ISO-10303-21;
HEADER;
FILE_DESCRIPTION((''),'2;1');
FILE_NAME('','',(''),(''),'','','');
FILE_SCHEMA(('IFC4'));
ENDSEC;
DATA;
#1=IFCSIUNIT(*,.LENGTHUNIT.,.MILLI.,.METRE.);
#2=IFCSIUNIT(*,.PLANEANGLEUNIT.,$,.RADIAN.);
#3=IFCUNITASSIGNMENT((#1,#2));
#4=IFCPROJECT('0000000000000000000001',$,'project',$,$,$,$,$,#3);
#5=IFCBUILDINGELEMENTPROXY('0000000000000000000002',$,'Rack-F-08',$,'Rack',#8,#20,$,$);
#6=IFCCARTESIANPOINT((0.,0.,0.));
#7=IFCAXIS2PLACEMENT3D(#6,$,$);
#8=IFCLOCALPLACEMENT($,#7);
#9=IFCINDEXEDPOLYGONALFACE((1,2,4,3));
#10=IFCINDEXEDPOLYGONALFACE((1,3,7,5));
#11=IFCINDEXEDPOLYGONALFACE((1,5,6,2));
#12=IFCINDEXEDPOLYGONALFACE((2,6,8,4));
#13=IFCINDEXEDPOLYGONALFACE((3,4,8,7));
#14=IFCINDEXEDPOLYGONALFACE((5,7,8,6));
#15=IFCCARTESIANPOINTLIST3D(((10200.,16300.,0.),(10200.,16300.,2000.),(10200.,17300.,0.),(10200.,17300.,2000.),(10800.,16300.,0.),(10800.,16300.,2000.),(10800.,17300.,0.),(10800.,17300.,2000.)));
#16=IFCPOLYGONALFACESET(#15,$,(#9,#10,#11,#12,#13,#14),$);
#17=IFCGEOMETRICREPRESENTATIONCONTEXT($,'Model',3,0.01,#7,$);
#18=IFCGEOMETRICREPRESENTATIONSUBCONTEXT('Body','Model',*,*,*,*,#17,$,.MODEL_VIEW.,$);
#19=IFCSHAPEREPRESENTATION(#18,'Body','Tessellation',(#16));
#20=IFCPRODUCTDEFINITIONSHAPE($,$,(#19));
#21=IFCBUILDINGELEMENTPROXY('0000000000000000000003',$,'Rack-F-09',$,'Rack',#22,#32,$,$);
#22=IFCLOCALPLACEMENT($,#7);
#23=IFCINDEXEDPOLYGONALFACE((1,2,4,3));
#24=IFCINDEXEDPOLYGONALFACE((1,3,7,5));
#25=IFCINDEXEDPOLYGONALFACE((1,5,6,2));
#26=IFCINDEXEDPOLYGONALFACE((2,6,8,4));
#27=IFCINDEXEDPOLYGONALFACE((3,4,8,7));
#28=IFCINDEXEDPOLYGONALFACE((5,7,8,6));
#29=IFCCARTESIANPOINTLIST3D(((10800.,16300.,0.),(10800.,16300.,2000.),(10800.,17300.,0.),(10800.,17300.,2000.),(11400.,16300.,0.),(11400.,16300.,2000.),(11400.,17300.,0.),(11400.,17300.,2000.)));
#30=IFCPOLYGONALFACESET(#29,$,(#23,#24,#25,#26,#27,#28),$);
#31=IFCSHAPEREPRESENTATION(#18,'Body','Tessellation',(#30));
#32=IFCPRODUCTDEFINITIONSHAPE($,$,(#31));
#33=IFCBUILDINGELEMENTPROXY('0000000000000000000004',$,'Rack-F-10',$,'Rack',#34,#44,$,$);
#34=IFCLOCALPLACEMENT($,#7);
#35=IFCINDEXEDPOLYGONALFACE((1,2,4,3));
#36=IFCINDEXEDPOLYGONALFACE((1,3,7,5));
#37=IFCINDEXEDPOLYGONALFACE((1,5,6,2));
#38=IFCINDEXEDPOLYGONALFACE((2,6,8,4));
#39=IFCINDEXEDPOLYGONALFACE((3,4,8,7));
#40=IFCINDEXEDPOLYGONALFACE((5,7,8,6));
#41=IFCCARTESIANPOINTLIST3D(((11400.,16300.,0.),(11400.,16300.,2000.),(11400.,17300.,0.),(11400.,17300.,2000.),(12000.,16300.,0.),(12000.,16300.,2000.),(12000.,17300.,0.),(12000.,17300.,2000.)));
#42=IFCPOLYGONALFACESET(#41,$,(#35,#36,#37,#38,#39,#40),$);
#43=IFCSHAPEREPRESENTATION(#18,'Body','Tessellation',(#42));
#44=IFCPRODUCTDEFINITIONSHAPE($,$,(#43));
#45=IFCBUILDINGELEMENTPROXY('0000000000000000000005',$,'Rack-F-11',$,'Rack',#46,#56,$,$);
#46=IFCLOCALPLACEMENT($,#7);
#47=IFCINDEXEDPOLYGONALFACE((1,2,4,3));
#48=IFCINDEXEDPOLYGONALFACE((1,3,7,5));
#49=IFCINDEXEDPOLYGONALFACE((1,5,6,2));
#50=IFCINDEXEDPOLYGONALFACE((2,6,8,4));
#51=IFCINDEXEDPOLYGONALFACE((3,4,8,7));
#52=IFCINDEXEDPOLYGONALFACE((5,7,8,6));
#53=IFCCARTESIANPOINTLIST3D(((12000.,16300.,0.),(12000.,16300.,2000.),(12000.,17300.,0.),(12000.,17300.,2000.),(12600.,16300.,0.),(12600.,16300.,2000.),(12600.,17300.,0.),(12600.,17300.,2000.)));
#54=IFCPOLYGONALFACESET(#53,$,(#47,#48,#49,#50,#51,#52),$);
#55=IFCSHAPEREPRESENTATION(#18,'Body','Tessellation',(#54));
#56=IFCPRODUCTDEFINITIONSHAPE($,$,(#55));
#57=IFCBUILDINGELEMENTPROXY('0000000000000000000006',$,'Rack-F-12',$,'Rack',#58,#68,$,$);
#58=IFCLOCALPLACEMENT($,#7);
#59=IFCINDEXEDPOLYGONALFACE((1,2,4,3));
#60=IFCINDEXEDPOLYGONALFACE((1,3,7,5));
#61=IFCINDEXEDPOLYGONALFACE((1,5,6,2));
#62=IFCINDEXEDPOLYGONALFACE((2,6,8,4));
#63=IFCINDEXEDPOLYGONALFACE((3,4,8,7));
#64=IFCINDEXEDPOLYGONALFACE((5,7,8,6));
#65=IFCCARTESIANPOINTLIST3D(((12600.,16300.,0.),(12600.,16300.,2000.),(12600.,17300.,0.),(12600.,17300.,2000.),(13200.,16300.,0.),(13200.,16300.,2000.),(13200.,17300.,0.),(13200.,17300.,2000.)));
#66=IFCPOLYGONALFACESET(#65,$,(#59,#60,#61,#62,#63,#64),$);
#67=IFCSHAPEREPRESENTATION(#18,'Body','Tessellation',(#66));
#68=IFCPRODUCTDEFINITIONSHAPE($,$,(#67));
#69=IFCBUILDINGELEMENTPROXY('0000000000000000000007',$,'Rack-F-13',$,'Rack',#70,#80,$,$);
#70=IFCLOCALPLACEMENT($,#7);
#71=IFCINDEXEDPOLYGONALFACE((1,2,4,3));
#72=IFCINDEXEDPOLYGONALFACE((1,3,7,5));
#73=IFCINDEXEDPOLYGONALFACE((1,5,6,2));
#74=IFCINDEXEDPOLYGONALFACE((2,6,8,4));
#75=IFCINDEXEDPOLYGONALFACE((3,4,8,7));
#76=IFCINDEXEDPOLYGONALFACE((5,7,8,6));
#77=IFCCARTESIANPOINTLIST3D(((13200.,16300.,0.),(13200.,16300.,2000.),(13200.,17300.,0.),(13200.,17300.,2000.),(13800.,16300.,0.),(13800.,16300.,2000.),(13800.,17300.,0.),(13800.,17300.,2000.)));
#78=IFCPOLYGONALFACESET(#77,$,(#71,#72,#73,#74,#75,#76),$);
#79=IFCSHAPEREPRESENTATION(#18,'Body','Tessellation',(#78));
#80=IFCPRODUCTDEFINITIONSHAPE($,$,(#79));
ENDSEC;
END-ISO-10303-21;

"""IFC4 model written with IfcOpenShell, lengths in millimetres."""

from ifc_helpers import new_model, si_unit, frame, origin, place, context, subcontext, project, rectangle, extrude, element, save


model = new_model("IFC4")

# Units and contexts
model_context = context("Model", 3, precision=0.01, world=origin())
body_context = subcontext(model_context, "Body", "Model", "MODEL_VIEW")
ifc_project = project(units=[si_unit("LENGTHUNIT", "METRE", prefix="MILLI"), si_unit("PLANEANGLEUNIT", "RADIAN")])

# Shared definitions
placement = place(None, origin())

# Building element proxies
for number, where, name in (
    (1, (10500.0, 16800.0, 0.0), "Rack-F-08"),
    (2, (11100.0, 16800.0, 0.0), "Rack-F-09"),
    (3, (11700.0, 16800.0, 0.0), "Rack-F-10"),
    (4, (12300.0, 16800.0, 0.0), "Rack-F-11"),
    (5, (12900.0, 16800.0, 0.0), "Rack-F-12"),
    (6, (13500.0, 16800.0, 0.0), "Rack-F-13"),
):
    element("IfcBuildingElementProxy", number, at=place(placement, frame(where)), Name=name, ObjectType="Rack", context=body_context, shape_type="SweptSolid", body=[
        extrude(rectangle(XDim=600.0, YDim=1000.0), origin(), (0.0, 0.0, 1.0), 2000.0),
    ])

save(model, "model.ifc")
